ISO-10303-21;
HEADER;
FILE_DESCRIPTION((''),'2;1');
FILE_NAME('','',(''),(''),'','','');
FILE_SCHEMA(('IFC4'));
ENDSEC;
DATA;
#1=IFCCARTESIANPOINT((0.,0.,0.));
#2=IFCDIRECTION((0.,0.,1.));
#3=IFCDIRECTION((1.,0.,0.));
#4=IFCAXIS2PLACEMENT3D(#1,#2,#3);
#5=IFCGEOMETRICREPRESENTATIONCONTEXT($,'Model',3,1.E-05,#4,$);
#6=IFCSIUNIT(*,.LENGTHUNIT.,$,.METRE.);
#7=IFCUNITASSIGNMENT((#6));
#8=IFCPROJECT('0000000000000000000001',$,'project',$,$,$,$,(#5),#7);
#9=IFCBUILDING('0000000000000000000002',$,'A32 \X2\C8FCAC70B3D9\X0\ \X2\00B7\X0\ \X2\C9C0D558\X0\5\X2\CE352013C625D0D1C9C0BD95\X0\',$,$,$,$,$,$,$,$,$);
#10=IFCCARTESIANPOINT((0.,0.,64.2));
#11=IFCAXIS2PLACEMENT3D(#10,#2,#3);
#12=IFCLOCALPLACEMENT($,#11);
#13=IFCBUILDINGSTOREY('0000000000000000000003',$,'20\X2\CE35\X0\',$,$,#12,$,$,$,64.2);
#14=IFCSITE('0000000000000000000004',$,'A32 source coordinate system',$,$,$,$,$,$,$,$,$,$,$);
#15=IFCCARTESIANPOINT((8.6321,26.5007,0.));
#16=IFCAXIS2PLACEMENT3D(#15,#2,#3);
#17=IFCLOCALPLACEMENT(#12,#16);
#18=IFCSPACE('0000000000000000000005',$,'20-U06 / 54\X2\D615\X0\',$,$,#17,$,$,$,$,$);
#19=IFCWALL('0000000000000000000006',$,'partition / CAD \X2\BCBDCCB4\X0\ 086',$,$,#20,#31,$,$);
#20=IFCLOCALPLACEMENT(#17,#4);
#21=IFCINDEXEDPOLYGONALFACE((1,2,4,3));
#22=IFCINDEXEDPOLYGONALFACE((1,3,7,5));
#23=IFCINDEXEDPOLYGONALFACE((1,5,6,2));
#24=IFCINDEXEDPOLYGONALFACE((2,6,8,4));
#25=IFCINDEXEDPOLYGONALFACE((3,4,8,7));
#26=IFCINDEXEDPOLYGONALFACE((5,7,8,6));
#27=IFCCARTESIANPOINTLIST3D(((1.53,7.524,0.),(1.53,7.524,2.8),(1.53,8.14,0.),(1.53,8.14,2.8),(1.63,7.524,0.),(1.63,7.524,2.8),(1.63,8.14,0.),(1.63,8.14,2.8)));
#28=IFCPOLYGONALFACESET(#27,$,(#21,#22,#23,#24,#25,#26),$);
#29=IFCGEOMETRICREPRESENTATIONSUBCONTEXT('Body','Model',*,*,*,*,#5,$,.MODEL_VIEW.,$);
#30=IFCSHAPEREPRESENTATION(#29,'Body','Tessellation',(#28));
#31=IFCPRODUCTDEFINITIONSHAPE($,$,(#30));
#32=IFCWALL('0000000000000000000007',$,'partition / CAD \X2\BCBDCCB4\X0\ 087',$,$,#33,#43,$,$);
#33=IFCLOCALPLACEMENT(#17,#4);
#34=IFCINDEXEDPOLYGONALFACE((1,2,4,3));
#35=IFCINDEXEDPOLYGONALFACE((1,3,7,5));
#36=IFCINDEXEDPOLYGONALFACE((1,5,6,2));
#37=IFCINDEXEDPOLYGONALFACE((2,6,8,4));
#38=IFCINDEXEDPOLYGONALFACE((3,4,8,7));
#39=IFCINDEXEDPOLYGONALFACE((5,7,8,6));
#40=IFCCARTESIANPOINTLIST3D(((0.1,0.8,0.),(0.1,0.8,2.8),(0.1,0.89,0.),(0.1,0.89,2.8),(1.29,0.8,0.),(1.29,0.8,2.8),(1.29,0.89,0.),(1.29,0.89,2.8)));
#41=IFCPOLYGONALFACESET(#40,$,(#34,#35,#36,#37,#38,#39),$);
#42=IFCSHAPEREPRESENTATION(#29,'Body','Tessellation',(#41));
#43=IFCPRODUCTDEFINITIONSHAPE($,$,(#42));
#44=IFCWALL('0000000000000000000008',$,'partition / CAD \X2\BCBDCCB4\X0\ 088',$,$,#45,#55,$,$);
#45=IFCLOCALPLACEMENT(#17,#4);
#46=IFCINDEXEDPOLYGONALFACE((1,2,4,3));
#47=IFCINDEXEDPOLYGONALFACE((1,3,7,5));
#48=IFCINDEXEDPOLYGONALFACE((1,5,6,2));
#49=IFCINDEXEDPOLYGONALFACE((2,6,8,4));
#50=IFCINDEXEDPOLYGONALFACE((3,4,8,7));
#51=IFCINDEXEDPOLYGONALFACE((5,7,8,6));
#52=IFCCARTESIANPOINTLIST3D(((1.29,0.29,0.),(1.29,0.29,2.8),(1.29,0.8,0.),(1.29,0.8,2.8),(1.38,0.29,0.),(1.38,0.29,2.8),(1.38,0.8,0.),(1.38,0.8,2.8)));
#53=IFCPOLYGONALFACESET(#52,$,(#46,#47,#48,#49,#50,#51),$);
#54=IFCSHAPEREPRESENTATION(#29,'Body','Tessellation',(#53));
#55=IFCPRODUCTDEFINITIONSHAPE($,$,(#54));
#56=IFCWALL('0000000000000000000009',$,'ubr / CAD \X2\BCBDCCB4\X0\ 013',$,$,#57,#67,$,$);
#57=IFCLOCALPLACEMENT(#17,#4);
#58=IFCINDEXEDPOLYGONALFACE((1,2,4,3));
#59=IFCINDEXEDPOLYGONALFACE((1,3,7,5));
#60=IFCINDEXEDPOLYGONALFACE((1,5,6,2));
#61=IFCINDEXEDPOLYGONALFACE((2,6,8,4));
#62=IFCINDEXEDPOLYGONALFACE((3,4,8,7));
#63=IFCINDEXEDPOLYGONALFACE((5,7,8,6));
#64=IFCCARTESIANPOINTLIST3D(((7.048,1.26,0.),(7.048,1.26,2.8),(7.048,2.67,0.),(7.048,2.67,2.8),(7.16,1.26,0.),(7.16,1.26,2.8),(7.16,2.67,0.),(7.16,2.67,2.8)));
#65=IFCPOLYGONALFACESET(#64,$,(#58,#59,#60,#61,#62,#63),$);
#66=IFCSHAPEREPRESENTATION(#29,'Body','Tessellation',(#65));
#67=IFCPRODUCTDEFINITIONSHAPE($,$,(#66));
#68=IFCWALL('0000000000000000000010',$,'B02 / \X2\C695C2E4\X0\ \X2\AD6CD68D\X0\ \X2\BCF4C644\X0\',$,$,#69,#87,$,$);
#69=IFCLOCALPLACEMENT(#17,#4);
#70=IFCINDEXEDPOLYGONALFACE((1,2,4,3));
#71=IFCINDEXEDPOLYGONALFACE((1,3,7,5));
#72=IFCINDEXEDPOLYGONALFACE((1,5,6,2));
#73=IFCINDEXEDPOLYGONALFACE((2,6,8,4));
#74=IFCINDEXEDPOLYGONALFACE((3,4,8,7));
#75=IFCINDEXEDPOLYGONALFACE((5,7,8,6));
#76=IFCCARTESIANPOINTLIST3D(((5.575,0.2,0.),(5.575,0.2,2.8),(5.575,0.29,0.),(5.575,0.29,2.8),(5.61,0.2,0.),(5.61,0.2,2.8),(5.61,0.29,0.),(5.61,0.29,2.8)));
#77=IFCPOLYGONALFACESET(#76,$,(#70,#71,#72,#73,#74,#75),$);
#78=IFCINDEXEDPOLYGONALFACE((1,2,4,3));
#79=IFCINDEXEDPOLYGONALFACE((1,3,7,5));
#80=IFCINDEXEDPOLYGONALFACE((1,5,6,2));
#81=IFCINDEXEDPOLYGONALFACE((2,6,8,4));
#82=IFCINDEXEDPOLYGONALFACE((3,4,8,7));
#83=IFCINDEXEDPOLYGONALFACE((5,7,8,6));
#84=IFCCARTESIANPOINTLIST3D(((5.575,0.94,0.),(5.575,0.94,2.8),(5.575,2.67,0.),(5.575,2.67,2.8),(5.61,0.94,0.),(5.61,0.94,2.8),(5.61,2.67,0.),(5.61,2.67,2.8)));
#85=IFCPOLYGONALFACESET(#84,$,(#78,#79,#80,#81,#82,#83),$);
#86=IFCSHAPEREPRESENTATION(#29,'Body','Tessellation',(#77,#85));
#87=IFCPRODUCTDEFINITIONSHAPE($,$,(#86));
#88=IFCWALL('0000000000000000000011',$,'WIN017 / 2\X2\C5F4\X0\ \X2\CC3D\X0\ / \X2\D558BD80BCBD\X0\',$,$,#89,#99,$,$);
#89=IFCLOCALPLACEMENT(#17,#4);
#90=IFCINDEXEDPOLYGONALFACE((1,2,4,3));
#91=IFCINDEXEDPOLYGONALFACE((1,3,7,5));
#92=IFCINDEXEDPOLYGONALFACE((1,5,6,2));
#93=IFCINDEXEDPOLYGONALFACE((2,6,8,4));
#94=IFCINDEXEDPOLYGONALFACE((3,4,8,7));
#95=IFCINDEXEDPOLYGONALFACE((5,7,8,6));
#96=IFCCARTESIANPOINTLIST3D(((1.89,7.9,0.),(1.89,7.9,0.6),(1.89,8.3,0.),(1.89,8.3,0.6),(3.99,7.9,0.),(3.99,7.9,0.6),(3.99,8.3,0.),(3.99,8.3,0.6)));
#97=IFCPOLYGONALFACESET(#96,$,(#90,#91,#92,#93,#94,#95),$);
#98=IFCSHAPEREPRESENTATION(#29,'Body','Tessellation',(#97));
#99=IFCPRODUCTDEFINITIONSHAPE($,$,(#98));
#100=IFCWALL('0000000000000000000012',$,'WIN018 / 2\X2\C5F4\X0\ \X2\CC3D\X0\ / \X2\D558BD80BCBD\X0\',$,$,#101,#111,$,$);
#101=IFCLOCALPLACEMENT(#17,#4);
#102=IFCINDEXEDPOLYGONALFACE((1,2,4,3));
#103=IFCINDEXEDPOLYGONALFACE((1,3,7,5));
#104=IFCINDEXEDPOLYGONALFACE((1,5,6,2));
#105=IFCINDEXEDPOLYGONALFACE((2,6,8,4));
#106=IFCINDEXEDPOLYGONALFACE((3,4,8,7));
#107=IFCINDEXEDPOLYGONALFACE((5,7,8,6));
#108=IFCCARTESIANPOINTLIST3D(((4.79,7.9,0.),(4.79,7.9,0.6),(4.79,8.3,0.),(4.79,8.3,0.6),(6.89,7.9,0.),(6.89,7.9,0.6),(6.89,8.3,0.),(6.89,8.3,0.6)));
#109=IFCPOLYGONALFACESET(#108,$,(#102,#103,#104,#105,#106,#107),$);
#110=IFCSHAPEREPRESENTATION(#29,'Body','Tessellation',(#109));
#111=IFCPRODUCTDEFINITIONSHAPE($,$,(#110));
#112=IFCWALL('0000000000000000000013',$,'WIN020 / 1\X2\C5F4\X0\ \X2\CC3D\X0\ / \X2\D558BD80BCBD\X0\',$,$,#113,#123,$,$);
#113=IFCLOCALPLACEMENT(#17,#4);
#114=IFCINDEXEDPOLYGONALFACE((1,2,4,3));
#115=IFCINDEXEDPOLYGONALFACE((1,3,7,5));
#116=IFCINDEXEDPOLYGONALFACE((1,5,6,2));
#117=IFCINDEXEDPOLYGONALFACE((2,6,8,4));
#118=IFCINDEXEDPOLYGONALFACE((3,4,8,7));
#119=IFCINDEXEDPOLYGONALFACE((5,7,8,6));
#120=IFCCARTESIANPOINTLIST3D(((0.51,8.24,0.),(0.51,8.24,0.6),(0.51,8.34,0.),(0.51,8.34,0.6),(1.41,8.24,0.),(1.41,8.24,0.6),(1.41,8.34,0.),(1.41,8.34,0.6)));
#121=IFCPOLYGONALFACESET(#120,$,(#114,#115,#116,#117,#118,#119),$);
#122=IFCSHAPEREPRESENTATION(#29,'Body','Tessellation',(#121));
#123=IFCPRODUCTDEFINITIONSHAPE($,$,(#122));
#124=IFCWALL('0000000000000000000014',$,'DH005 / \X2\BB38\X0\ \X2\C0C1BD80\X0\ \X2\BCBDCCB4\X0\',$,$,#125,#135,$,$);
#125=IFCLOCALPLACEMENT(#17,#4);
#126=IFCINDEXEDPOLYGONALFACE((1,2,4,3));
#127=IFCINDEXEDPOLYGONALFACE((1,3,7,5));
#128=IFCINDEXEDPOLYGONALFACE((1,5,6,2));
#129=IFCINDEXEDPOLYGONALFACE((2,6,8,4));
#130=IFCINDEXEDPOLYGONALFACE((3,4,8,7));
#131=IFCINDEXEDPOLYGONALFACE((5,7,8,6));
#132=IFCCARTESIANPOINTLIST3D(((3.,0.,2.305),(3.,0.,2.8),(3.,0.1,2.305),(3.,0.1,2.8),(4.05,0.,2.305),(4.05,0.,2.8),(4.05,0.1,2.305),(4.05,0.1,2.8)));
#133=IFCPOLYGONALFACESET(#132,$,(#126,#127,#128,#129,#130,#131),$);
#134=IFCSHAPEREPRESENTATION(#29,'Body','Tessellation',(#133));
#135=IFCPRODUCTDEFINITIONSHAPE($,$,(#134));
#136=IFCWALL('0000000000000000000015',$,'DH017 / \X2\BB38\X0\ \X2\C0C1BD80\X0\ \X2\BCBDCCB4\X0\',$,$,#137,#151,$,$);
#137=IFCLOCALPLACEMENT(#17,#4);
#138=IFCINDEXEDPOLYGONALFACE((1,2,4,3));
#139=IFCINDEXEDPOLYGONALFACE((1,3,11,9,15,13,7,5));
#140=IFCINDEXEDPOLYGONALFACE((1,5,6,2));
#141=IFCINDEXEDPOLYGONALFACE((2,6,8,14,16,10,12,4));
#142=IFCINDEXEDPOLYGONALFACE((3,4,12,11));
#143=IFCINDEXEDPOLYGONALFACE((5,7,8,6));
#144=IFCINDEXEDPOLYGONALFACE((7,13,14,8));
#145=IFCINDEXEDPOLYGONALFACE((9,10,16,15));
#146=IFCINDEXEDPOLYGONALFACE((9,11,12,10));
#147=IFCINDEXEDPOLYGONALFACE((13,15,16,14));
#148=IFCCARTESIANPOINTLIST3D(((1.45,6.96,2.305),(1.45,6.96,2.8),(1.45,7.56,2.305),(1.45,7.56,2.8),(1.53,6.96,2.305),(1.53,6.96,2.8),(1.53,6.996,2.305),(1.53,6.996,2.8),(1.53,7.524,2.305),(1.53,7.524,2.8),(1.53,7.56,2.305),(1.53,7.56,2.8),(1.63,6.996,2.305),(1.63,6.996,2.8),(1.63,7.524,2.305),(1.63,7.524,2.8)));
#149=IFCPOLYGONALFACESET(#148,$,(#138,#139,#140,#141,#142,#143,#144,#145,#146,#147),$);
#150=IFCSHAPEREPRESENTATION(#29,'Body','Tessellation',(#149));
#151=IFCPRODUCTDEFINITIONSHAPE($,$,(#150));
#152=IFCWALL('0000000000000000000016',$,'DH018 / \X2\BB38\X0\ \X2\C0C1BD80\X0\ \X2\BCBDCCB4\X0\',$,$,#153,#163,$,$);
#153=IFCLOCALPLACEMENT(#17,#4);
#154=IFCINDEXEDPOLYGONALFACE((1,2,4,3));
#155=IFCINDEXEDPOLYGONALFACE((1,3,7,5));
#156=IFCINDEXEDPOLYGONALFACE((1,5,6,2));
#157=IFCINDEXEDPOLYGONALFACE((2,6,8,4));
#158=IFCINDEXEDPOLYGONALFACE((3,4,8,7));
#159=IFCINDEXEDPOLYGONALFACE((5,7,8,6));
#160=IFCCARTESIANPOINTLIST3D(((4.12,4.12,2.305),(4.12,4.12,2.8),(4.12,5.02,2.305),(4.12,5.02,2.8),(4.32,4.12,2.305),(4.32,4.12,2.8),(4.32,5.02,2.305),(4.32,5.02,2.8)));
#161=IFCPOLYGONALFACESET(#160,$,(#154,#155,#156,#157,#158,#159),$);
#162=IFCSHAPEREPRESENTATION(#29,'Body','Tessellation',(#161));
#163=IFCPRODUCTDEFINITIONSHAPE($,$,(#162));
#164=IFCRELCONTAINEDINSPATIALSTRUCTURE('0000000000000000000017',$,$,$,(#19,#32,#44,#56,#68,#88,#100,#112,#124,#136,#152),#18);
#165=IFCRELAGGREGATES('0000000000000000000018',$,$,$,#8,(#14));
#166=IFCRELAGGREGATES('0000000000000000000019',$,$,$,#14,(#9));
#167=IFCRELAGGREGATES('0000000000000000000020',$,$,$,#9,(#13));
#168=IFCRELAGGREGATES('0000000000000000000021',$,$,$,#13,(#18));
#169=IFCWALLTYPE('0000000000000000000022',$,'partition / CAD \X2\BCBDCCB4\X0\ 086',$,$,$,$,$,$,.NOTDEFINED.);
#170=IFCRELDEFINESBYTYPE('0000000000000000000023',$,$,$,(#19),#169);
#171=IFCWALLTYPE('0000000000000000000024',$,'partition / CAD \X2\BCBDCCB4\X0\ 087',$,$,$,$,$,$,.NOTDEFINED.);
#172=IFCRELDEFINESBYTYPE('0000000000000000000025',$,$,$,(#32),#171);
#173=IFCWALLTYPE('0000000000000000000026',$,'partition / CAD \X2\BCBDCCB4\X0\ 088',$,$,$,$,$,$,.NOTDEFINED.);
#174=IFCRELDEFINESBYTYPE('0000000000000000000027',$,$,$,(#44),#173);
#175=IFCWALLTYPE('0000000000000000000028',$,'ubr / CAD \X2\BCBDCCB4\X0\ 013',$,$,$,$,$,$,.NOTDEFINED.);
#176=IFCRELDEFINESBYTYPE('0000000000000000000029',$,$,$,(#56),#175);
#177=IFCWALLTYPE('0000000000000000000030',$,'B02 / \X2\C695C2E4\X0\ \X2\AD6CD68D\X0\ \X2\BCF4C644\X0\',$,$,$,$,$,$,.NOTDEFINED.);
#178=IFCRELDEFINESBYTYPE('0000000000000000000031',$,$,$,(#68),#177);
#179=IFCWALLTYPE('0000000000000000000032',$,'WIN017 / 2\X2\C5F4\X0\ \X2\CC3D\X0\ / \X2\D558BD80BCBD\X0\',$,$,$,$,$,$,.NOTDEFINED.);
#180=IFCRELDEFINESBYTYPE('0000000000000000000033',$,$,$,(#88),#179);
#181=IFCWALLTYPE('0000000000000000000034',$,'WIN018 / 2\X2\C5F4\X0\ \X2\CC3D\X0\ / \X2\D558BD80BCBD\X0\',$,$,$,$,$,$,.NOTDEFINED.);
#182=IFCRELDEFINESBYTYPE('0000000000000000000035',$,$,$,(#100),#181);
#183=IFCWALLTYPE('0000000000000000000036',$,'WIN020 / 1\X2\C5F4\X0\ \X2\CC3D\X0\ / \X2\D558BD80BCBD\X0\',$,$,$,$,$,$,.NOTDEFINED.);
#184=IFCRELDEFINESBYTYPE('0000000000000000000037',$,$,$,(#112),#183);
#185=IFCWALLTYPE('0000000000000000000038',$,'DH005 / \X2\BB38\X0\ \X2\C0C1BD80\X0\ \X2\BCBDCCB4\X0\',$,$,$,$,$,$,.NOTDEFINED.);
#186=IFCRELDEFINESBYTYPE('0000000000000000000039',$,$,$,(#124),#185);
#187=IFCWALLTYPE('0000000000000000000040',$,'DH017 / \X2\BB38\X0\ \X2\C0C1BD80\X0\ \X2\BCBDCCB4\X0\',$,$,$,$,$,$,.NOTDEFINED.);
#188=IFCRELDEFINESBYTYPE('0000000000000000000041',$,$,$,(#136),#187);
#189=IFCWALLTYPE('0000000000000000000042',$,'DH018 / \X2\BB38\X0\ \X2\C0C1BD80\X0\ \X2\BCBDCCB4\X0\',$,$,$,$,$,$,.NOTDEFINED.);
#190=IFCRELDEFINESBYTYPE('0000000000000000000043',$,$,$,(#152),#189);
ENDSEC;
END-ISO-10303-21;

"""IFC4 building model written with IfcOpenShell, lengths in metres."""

from ifc_helpers import new_model, si_unit, frame, origin, origin_with_axes, place, context, subcontext, project, spatial, polyline, outline, extrude, source, transform, mapped, type_object, type_shapes, element, save


model = new_model("IFC4")

# Units and contexts
model_context = context("Model", 3, precision=1e-05, world=origin_with_axes())
body_context = subcontext(model_context, "Body", "Model", "MODEL_VIEW")
ifc_project = project(units=[si_unit("LENGTHUNIT", "METRE")], contexts=[model_context])

# Site, building, storey, space
site = spatial("IfcSite", under=ifc_project, Name="A32 source coordinate system")
building = spatial("IfcBuilding", under=site, Name="A32 주거동 · 지하5층–옥탑지붕")
storey_placement = place(None, frame((0.0, 0.0, 64.2), z_axis=(0.0, 0.0, 1.0), x_axis=(1.0, 0.0, 0.0)))
storey = spatial("IfcBuildingStorey", under=building, at=storey_placement, Name="20층", Elevation=64.2)
space_placement = place(storey_placement, frame((8.6321, 26.5007, 0.0), z_axis=(0.0, 0.0, 1.0), x_axis=(1.0, 0.0, 0.0)))
space = spatial("IfcSpace", under=storey, at=space_placement, Name="20-U06 / 54형")

# Walls
wall_type_1 = type_object("IfcWallType", Name="partition / CAD 벽체 086", PredefinedType="NOTDEFINED")
shared_shape_1 = source(origin(), body_context, "Body", "SweptSolid", [
    extrude(outline(polyline([(1.53, 7.524), (1.53, 8.14), (1.63, 8.14), (1.63, 7.524), (1.53, 7.524)])), origin(), (0.0, 0.0, 1.0), 2.8),
])
type_shapes(wall_type_1, [shared_shape_1])
wall_1_placement = place(space_placement, origin_with_axes())
element("IfcWall", 1, at=wall_1_placement, inside=space, type_object=wall_type_1, Name="partition / CAD 벽체 086", context=body_context, shape_type="MappedRepresentation", body=[
    mapped(shared_shape_1, transform((0.0, 0.0, 0.0), scale=1.0)),
])
wall_type_2 = type_object("IfcWallType", Name="partition / CAD 벽체 087", PredefinedType="NOTDEFINED")
shared_shape_2 = source(origin(), body_context, "Body", "SweptSolid", [
    extrude(outline(polyline([(1.29, 0.8), (0.1, 0.8), (0.1, 0.89), (1.29, 0.89), (1.29, 0.8)])), origin(), (0.0, 0.0, 1.0), 2.8),
])
type_shapes(wall_type_2, [shared_shape_2])
wall_2_placement = place(space_placement, origin_with_axes())
element("IfcWall", 2, at=wall_2_placement, inside=space, type_object=wall_type_2, Name="partition / CAD 벽체 087", context=body_context, shape_type="MappedRepresentation", body=[
    mapped(shared_shape_2, transform((0.0, 0.0, 0.0), scale=1.0)),
])
wall_type_3 = type_object("IfcWallType", Name="partition / CAD 벽체 088", PredefinedType="NOTDEFINED")
shared_shape_3 = source(origin(), body_context, "Body", "SweptSolid", [
    extrude(outline(polyline([(1.29, 0.29), (1.29, 0.8), (1.38, 0.8), (1.38, 0.29), (1.29, 0.29)])), origin(), (0.0, 0.0, 1.0), 2.8),
])
type_shapes(wall_type_3, [shared_shape_3])
wall_3_placement = place(space_placement, origin_with_axes())
element("IfcWall", 3, at=wall_3_placement, inside=space, type_object=wall_type_3, Name="partition / CAD 벽체 088", context=body_context, shape_type="MappedRepresentation", body=[
    mapped(shared_shape_3, transform((0.0, 0.0, 0.0), scale=1.0)),
])
wall_type_4 = type_object("IfcWallType", Name="ubr / CAD 벽체 013", PredefinedType="NOTDEFINED")
shared_shape_4 = source(origin(), body_context, "Body", "SweptSolid", [
    extrude(outline(polyline([(7.16, 1.26), (7.048, 1.26), (7.048, 2.67), (7.16, 2.67), (7.16, 1.26)])), origin(), (0.0, 0.0, 1.0), 2.8),
])
type_shapes(wall_type_4, [shared_shape_4])
wall_4_placement = place(space_placement, origin_with_axes())
element("IfcWall", 4, at=wall_4_placement, inside=space, type_object=wall_type_4, Name="ubr / CAD 벽체 013", context=body_context, shape_type="MappedRepresentation", body=[
    mapped(shared_shape_4, transform((0.0, 0.0, 0.0), scale=1.0)),
])
wall_type_5 = type_object("IfcWallType", Name="B02 / 욕실 구획 보완", PredefinedType="NOTDEFINED")
shared_shape_5 = source(origin(), body_context, "Body", "SweptSolid", [
    extrude(outline(polyline([(5.575, 0.2), (5.575, 0.29), (5.61, 0.29), (5.61, 0.2), (5.575, 0.2)])), origin(), (0.0, 0.0, 1.0), 2.8),
    extrude(outline(polyline([(5.575, 0.94), (5.575, 2.67), (5.61, 2.67), (5.61, 0.94), (5.575, 0.94)])), origin(), (0.0, 0.0, 1.0), 2.8),
])
type_shapes(wall_type_5, [shared_shape_5])
wall_5_placement = place(space_placement, origin_with_axes())
element("IfcWall", 5, at=wall_5_placement, inside=space, type_object=wall_type_5, Name="B02 / 욕실 구획 보완", context=body_context, shape_type="MappedRepresentation", body=[
    mapped(shared_shape_5, transform((0.0, 0.0, 0.0), scale=1.0)),
])
wall_type_6 = type_object("IfcWallType", Name="WIN017 / 2열 창 / 하부벽", PredefinedType="NOTDEFINED")
shared_shape_6 = source(origin(), body_context, "Body", "SweptSolid", [
    extrude(outline(polyline([(3.99, 8.3), (3.99, 7.9), (1.89, 7.9), (1.89, 8.3), (3.99, 8.3)])), origin(), (0.0, 0.0, 1.0), 0.6),
])
type_shapes(wall_type_6, [shared_shape_6])
wall_6_placement = place(space_placement, origin_with_axes())
element("IfcWall", 6, at=wall_6_placement, inside=space, type_object=wall_type_6, Name="WIN017 / 2열 창 / 하부벽", context=body_context, shape_type="MappedRepresentation", body=[
    mapped(shared_shape_6, transform((0.0, 0.0, 0.0), scale=1.0)),
])
wall_type_7 = type_object("IfcWallType", Name="WIN018 / 2열 창 / 하부벽", PredefinedType="NOTDEFINED")
shared_shape_7 = source(origin(), body_context, "Body", "SweptSolid", [
    extrude(outline(polyline([(6.89, 8.3), (6.89, 7.9), (4.79, 7.9), (4.79, 8.3), (6.89, 8.3)])), origin(), (0.0, 0.0, 1.0), 0.6),
])
type_shapes(wall_type_7, [shared_shape_7])
wall_7_placement = place(space_placement, origin_with_axes())
element("IfcWall", 7, at=wall_7_placement, inside=space, type_object=wall_type_7, Name="WIN018 / 2열 창 / 하부벽", context=body_context, shape_type="MappedRepresentation", body=[
    mapped(shared_shape_7, transform((0.0, 0.0, 0.0), scale=1.0)),
])
wall_type_8 = type_object("IfcWallType", Name="WIN020 / 1열 창 / 하부벽", PredefinedType="NOTDEFINED")
shared_shape_8 = source(origin(), body_context, "Body", "SweptSolid", [
    extrude(outline(polyline([(1.41, 8.34), (1.41, 8.24), (0.51, 8.24), (0.51, 8.34), (1.41, 8.34)])), origin(), (0.0, 0.0, 1.0), 0.6),
])
type_shapes(wall_type_8, [shared_shape_8])
wall_8_placement = place(space_placement, origin_with_axes())
element("IfcWall", 8, at=wall_8_placement, inside=space, type_object=wall_type_8, Name="WIN020 / 1열 창 / 하부벽", context=body_context, shape_type="MappedRepresentation", body=[
    mapped(shared_shape_8, transform((0.0, 0.0, 0.0), scale=1.0)),
])
wall_type_9 = type_object("IfcWallType", Name="DH005 / 문 상부 벽체", PredefinedType="NOTDEFINED")
shared_shape_9 = source(origin(), body_context, "Body", "SweptSolid", [
    extrude(outline(polyline([(4.05, 0.0), (3.0, 0.0), (3.0, 0.1), (4.05, 0.1), (4.05, 0.0)])), frame((0.0, 0.0, 2.305)), (0.0, 0.0, 1.0), 0.495),
])
type_shapes(wall_type_9, [shared_shape_9])
wall_9_placement = place(space_placement, origin_with_axes())
element("IfcWall", 9, at=wall_9_placement, inside=space, type_object=wall_type_9, Name="DH005 / 문 상부 벽체", context=body_context, shape_type="MappedRepresentation", body=[
    mapped(shared_shape_9, transform((0.0, 0.0, 0.0), scale=1.0)),
])
wall_type_10 = type_object("IfcWallType", Name="DH017 / 문 상부 벽체", PredefinedType="NOTDEFINED")
shared_shape_10 = source(origin(), body_context, "Body", "SweptSolid", [
    extrude(outline(polyline([(1.63, 7.524), (1.63, 6.996), (1.53, 6.996), (1.53, 6.96), (1.45, 6.96), (1.45, 7.56), (1.53, 7.56), (1.53, 7.524), (1.63, 7.524)])), frame((0.0, 0.0, 2.305)), (0.0, 0.0, 1.0), 0.495),
])
type_shapes(wall_type_10, [shared_shape_10])
wall_10_placement = place(space_placement, origin_with_axes())
element("IfcWall", 10, at=wall_10_placement, inside=space, type_object=wall_type_10, Name="DH017 / 문 상부 벽체", context=body_context, shape_type="MappedRepresentation", body=[
    mapped(shared_shape_10, transform((0.0, 0.0, 0.0), scale=1.0)),
])
wall_type_11 = type_object("IfcWallType", Name="DH018 / 문 상부 벽체", PredefinedType="NOTDEFINED")
shared_shape_11 = source(origin(), body_context, "Body", "SweptSolid", [
    extrude(outline(polyline([(4.32, 4.12), (4.12, 4.12), (4.12, 5.02), (4.32, 5.02), (4.32, 4.12)])), frame((0.0, 0.0, 2.305)), (0.0, 0.0, 1.0), 0.495),
])
type_shapes(wall_type_11, [shared_shape_11])
wall_11_placement = place(space_placement, origin_with_axes())
element("IfcWall", 11, at=wall_11_placement, inside=space, type_object=wall_type_11, Name="DH018 / 문 상부 벽체", context=body_context, shape_type="MappedRepresentation", body=[
    mapped(shared_shape_11, transform((0.0, 0.0, 0.0), scale=1.0)),
])

save(model, "model.ifc")
